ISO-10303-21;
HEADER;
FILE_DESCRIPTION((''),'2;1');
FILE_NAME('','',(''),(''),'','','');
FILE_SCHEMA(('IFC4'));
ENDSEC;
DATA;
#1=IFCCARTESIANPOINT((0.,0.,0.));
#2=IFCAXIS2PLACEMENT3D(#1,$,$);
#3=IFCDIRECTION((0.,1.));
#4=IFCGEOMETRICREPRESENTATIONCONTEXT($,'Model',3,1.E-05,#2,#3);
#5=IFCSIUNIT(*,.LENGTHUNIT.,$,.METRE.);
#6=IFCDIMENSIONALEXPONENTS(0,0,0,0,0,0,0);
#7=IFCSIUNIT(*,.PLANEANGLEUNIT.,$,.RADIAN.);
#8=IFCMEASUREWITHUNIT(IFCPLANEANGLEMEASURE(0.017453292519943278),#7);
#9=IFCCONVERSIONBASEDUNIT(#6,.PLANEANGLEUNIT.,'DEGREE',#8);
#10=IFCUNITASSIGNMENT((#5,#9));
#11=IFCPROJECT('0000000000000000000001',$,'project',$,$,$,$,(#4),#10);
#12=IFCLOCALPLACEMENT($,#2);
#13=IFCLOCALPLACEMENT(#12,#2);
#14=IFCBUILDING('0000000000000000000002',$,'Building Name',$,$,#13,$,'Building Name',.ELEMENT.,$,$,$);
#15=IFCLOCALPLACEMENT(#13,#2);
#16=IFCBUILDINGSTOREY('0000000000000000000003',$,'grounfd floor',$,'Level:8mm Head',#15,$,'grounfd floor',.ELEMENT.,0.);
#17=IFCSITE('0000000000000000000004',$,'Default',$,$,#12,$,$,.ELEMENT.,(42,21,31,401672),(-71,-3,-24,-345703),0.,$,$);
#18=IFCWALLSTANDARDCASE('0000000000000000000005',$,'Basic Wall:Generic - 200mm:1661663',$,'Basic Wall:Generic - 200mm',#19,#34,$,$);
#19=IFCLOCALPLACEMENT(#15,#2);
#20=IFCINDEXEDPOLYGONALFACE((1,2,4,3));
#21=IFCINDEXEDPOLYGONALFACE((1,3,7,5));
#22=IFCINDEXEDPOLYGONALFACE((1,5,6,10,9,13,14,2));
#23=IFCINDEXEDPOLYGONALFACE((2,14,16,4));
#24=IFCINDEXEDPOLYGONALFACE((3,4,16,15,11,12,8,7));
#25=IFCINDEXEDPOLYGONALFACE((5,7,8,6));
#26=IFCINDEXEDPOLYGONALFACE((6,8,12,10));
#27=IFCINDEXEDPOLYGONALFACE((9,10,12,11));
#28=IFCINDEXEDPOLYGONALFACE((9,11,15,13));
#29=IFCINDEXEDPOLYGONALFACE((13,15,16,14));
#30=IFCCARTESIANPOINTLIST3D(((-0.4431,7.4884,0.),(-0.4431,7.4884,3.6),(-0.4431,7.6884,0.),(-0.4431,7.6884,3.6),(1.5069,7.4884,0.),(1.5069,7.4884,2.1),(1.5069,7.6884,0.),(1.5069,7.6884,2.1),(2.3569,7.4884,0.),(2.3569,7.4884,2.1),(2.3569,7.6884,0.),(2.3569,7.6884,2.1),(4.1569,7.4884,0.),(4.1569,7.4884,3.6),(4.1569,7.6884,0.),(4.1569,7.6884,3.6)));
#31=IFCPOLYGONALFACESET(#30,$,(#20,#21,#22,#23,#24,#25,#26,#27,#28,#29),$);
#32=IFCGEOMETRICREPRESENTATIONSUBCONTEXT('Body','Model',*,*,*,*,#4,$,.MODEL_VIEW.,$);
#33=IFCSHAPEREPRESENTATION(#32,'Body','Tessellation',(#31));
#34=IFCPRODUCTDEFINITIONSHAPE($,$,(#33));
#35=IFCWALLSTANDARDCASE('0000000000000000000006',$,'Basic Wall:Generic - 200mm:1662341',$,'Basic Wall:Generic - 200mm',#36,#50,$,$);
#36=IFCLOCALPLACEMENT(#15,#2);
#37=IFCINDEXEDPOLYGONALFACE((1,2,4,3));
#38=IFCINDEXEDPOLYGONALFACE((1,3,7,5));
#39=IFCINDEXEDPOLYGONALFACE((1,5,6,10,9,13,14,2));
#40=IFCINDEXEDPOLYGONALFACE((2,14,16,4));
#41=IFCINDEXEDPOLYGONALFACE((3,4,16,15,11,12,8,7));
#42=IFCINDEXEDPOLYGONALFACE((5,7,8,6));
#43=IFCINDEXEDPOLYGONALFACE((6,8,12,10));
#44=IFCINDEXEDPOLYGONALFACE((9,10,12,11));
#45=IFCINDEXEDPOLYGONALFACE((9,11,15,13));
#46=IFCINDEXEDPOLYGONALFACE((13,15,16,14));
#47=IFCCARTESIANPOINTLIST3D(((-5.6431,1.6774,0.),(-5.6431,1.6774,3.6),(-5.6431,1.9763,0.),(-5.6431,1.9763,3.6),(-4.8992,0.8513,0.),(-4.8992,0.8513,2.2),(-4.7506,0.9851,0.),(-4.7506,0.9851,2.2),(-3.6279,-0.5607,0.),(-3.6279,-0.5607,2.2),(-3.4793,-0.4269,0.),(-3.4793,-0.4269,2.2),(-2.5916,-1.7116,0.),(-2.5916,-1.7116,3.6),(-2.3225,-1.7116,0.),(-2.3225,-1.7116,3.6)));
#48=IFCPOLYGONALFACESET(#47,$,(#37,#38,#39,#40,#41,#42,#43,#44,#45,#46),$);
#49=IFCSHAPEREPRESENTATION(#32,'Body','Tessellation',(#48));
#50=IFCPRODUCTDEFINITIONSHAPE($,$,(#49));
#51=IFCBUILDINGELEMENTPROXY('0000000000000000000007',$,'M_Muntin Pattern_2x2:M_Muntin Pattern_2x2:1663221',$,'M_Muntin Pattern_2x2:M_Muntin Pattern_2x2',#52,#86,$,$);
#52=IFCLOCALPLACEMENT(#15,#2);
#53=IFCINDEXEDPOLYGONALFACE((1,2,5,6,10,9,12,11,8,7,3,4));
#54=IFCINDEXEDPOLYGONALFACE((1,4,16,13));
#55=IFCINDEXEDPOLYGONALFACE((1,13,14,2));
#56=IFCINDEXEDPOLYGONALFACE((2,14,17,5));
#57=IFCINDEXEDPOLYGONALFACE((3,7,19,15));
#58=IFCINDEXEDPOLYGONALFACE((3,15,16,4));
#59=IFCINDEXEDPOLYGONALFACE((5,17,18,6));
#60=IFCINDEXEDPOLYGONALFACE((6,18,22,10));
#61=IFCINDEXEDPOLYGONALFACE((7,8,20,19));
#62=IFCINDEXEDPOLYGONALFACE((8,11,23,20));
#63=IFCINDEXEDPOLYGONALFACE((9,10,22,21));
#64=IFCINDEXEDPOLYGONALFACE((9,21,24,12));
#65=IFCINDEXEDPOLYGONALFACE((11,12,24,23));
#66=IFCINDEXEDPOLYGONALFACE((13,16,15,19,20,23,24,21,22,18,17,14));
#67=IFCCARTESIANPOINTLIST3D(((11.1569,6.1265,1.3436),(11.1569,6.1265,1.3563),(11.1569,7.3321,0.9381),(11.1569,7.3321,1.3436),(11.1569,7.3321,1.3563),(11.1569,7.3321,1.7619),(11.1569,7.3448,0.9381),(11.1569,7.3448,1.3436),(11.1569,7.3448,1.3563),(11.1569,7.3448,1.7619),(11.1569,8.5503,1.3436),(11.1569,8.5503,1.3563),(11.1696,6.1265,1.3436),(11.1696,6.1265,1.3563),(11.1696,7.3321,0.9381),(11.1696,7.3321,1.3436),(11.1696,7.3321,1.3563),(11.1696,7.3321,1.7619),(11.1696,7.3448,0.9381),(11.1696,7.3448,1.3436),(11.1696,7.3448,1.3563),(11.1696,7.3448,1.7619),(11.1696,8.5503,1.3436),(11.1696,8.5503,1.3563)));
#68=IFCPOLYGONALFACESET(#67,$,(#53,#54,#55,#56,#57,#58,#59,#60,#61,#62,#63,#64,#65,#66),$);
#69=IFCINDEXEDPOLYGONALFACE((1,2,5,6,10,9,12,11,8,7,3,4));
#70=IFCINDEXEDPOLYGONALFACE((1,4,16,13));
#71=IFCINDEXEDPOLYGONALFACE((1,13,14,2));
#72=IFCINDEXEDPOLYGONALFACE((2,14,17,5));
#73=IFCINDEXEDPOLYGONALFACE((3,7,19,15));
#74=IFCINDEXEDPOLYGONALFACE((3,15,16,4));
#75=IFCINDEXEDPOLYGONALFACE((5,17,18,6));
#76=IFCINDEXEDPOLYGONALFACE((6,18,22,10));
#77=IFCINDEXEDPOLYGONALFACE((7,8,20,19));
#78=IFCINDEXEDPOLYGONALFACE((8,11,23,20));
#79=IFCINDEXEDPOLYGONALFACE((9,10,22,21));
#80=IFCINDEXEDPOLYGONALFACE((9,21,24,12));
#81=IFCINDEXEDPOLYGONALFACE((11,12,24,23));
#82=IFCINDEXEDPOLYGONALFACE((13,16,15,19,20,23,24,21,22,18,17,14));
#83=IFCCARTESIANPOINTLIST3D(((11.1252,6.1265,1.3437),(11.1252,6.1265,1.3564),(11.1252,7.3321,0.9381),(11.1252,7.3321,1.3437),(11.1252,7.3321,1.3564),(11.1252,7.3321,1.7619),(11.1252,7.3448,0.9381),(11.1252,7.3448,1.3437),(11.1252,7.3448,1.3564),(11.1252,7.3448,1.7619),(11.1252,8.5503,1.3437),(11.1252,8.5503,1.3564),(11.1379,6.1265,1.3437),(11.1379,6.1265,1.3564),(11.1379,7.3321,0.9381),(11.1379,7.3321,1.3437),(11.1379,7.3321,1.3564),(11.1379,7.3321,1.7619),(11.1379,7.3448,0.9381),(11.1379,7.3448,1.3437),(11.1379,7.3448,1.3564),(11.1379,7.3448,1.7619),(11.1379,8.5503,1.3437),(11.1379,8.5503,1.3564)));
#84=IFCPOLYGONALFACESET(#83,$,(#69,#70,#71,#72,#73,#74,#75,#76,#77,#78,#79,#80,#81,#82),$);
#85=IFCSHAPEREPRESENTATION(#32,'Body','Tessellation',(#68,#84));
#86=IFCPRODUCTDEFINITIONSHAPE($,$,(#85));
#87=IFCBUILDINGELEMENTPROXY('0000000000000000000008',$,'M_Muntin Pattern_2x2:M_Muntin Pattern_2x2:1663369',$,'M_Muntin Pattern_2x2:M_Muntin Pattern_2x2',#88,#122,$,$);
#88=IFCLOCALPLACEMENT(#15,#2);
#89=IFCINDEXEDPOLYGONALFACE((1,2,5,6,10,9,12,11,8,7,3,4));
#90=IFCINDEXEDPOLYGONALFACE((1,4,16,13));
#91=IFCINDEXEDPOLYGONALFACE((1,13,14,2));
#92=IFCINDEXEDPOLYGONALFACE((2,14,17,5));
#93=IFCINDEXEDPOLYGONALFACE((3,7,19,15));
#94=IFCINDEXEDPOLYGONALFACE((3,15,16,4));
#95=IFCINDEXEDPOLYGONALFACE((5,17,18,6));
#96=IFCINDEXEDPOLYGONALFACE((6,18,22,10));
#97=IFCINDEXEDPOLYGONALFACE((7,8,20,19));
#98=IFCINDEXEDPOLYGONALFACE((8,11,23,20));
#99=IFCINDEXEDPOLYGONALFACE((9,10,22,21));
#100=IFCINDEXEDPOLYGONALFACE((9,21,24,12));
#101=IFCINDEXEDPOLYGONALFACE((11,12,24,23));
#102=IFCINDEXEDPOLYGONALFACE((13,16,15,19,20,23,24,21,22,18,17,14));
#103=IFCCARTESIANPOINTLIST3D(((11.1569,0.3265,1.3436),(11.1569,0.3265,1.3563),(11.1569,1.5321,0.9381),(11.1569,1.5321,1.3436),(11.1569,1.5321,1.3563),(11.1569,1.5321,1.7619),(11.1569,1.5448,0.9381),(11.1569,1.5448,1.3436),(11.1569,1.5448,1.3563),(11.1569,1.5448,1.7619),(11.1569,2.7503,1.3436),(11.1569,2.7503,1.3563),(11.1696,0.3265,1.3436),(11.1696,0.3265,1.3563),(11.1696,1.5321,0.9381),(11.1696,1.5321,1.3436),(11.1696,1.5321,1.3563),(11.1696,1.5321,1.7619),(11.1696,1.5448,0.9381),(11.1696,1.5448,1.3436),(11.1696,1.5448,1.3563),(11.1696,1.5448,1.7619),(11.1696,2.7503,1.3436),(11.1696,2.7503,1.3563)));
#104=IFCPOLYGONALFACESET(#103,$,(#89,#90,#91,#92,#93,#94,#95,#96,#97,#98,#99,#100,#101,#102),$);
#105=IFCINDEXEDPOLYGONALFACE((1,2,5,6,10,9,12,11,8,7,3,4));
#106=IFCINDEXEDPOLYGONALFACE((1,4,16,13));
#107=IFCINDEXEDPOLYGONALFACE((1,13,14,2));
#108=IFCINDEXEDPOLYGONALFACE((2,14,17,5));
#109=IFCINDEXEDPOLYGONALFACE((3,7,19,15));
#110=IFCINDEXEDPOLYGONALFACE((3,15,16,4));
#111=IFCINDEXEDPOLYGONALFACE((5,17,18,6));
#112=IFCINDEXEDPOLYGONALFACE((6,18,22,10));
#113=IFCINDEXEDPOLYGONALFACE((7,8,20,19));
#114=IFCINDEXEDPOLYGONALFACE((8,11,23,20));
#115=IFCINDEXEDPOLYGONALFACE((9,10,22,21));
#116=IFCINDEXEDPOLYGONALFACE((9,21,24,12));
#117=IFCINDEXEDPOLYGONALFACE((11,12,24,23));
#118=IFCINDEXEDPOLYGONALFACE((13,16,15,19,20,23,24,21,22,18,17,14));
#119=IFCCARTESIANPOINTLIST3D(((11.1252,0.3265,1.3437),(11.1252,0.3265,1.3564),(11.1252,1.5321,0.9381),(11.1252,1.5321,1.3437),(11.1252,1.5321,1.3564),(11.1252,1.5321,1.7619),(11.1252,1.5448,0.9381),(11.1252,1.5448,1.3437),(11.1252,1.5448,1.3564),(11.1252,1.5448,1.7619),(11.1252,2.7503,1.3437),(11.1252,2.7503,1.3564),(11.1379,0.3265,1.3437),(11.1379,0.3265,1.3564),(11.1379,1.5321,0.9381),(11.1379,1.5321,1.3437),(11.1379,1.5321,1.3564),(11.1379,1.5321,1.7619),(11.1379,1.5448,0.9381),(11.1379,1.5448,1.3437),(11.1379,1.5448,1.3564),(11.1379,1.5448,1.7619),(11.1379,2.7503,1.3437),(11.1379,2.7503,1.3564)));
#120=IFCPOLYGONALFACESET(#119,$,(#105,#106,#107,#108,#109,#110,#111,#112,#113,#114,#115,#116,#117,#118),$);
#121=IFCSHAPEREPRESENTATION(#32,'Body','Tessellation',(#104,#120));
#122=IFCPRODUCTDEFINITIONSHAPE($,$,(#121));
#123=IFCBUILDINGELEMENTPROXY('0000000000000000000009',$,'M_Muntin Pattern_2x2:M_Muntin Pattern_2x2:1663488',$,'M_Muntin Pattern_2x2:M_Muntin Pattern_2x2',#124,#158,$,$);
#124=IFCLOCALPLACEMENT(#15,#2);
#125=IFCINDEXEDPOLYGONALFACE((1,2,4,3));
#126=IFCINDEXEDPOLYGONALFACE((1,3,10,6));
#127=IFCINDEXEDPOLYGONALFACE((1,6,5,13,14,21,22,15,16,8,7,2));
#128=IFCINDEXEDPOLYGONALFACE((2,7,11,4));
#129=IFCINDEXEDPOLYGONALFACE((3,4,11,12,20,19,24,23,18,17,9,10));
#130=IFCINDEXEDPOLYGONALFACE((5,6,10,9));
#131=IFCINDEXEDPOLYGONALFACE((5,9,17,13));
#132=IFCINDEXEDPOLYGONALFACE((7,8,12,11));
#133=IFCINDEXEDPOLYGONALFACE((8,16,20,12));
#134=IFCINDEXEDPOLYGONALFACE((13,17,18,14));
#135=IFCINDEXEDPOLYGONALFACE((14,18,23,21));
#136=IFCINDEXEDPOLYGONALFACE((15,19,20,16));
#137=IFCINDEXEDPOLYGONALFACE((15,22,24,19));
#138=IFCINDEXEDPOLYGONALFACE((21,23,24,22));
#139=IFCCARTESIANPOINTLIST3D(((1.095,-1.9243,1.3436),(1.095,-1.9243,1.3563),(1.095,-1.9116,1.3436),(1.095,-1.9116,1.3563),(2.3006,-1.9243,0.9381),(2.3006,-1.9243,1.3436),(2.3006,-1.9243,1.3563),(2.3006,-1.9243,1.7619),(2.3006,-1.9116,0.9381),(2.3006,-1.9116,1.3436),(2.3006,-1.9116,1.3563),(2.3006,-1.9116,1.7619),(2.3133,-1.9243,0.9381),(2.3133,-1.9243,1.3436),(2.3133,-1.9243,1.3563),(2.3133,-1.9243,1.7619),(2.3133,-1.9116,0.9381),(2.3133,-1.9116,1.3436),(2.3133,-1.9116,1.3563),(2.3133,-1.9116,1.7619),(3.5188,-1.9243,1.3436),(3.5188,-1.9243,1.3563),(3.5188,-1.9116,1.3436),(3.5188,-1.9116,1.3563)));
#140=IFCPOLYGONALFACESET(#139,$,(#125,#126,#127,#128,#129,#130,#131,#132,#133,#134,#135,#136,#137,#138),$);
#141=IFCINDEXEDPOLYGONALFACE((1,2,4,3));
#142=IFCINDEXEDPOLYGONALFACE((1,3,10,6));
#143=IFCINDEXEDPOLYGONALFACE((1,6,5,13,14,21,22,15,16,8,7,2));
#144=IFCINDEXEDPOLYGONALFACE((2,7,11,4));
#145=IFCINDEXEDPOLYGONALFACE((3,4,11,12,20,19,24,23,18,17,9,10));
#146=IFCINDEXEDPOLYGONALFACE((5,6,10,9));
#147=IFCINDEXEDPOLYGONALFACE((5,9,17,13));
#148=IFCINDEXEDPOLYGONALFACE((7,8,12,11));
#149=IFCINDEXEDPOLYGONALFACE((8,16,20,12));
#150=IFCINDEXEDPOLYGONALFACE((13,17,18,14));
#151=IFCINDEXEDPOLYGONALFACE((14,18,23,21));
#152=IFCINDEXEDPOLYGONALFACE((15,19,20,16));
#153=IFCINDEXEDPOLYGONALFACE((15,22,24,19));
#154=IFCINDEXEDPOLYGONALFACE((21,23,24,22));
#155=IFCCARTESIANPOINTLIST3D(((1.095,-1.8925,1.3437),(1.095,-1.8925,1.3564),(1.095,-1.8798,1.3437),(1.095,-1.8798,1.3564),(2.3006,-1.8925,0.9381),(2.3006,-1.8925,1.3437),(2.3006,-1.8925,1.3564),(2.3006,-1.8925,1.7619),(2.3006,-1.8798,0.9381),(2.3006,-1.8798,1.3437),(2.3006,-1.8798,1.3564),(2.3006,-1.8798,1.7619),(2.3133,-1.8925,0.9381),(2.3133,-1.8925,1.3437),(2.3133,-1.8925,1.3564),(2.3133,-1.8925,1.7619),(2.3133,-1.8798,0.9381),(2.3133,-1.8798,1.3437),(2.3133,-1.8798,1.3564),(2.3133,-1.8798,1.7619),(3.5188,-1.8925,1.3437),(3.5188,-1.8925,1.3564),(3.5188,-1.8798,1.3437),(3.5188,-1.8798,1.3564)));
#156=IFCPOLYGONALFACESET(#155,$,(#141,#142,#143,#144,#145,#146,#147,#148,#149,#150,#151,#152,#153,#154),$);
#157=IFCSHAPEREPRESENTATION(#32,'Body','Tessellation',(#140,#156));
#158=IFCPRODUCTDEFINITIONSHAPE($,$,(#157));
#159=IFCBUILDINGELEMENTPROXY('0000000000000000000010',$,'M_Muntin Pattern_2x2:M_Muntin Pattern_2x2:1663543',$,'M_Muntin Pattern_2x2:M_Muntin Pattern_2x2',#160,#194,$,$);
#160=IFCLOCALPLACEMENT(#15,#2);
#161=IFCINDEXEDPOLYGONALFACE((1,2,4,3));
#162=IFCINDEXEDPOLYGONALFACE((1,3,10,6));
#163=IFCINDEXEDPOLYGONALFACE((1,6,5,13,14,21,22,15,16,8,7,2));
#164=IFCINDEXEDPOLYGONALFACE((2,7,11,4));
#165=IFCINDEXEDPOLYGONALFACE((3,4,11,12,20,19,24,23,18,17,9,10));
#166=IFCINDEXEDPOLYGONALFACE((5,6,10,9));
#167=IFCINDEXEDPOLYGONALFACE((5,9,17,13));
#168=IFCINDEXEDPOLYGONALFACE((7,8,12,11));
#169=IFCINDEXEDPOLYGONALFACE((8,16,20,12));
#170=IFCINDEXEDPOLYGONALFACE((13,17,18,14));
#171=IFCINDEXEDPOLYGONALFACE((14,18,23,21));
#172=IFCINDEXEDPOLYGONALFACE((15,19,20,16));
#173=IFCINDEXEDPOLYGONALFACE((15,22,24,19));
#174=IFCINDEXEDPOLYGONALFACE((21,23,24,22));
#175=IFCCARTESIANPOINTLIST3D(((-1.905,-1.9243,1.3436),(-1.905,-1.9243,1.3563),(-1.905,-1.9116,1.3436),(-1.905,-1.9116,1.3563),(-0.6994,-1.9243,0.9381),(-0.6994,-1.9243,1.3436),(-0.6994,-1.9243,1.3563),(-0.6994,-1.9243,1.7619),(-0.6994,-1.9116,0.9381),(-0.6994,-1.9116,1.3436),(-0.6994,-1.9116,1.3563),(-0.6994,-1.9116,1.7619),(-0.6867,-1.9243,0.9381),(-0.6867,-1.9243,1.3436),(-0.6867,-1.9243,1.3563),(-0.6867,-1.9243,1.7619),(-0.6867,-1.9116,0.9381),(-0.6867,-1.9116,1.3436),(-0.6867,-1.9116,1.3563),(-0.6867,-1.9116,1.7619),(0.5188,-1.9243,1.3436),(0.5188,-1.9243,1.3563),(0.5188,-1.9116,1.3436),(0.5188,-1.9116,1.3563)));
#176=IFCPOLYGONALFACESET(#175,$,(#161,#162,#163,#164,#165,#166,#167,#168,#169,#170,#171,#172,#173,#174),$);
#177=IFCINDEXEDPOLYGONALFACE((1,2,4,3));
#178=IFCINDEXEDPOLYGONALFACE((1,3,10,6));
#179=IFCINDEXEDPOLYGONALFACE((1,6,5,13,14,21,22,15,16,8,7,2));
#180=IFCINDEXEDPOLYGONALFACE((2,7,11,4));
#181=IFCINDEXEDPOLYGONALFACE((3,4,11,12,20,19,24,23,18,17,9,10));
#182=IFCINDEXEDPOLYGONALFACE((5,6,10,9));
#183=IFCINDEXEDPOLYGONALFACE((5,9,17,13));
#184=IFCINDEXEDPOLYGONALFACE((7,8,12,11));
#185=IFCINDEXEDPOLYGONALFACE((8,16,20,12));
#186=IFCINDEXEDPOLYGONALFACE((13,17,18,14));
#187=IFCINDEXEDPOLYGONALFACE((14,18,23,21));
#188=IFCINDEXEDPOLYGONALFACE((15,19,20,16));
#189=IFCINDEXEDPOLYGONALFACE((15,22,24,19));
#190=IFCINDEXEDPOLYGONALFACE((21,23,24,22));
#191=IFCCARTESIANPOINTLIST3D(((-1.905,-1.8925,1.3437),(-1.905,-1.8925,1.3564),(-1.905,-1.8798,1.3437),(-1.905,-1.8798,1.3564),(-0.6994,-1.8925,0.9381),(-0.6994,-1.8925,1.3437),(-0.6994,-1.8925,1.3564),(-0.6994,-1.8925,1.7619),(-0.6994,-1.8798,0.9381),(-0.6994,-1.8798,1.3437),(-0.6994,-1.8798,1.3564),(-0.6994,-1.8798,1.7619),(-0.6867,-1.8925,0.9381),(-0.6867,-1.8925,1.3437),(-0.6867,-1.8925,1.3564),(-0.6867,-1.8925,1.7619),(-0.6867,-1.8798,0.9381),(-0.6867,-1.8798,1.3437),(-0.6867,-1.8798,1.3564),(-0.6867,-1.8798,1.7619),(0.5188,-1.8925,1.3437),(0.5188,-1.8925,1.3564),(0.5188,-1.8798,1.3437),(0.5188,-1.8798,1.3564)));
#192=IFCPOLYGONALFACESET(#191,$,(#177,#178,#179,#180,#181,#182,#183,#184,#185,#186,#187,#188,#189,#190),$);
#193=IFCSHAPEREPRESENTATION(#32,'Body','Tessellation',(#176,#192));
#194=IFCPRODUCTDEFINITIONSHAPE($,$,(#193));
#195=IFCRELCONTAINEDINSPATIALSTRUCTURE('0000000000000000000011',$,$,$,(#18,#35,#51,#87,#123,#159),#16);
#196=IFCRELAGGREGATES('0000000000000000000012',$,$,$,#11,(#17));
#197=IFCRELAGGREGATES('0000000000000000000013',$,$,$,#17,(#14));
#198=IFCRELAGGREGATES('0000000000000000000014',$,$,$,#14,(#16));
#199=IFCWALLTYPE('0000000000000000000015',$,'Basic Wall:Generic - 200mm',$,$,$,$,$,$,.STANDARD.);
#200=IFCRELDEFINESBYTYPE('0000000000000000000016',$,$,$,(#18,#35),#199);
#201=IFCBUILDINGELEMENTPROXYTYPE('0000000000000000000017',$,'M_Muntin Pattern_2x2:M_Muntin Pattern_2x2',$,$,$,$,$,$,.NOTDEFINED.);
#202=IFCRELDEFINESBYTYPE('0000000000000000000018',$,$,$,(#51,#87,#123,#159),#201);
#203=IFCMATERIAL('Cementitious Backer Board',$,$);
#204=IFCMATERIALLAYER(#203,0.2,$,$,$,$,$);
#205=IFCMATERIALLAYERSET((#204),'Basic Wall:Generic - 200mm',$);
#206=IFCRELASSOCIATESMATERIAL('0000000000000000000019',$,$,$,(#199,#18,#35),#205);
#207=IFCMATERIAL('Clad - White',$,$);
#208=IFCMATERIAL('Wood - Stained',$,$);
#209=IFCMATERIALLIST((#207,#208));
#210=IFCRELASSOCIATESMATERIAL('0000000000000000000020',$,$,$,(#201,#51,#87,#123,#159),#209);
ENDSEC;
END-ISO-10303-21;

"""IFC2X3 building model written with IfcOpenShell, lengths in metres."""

from ifc_helpers import new_model, entity, si_unit, converted_unit, direction, frame, frame_2d, origin, place, context, subcontext, project, spatial, polyline, rectangle, outline, extrude, source, transform, mapped, material, material_list, layer, layer_set, layer_usage, type_object, type_shapes, element, save


model = new_model("IFC2X3")

# Units and contexts
model_context = context("Model", 3, precision=1e-05, world=origin(), true_north=direction((0.0, 1.0)))
body_context = subcontext(model_context, "Body", "Model", "MODEL_VIEW")
ifc_project = project(units=[si_unit("LENGTHUNIT", "METRE"), converted_unit("PLANEANGLEUNIT", "DEGREE", entity("IfcPlaneAngleMeasure", 0.017453292519943278), si_unit("PLANEANGLEUNIT", "RADIAN"), dimensions=[0, 0, 0, 0, 0, 0, 0])], contexts=[model_context])

# Site, building, storey
site_placement = place(None, origin())
site = spatial("IfcSite", under=ifc_project, at=site_placement, Name="Default", CompositionType="ELEMENT", RefLatitude=(42, 21, 31, 401672), RefLongitude=(-71, -3, -24, -345703), RefElevation=0.0)
building_placement = place(site_placement, origin())
building = spatial("IfcBuilding", under=site, at=building_placement, Name="Building Name", LongName="Building Name", CompositionType="ELEMENT")
storey_placement = place(building_placement, origin())
storey = spatial("IfcBuildingStorey", under=building, at=storey_placement, Name="grounfd floor", ObjectType="Level:8mm Head", LongName="grounfd floor", CompositionType="ELEMENT", Elevation=0.0)

# Shared definitions
ifc_material_1 = material(Name="Cementitious Backer Board")
ifc_layer_1 = layer(ifc_material_1, 0.2)
ifc_layer_set_1 = layer_set([ifc_layer_1], Name="Basic Wall:Generic - 200mm")
wall_type = type_object("IfcWallType", Name="Basic Wall:Generic - 200mm", PredefinedType="STANDARD", material=ifc_layer_set_1)

# Walls, openings
ifc_layer_usage_1 = layer_usage(ifc_layer_set_1, "AXIS2", "NEGATIVE", 0.1)
wall_1_placement = place(storey_placement, frame((-0.4431, 7.5884, 0.0)))
wall_1 = element("IfcWallStandardCase", 1, at=wall_1_placement, inside=storey, type_object=wall_type, material=ifc_layer_usage_1, Name="Basic Wall:Generic - 200mm:1661663", ObjectType="Basic Wall:Generic - 200mm", context=body_context, shape_type="SweptSolid", body=[
    extrude(rectangle(XDim=4.6, YDim=0.2, at=frame_2d((2.3, 0.0), x_axis=(-1.0, 0.0))), origin(), (0.0, 0.0, 1.0), 3.6),
])
opening_1_placement = place(wall_1_placement, frame((1.95, -0.1, 0.0)))
element("IfcOpeningElement", 2, at=opening_1_placement, cuts=wall_1, ObjectType="Opening", context=body_context, shape_type="SweptSolid", body=[
    extrude(rectangle(XDim=2.1, YDim=0.85, at=frame_2d((1.05, 0.425), x_axis=(1.0, 0.0))), frame((0.0, 0.0, 0.0), z_axis=(0.0, 1.0, 0.0), x_axis=(0.0, 0.0, 1.0)), (0.0, 0.0, 1.0), 0.2),
])
ifc_layer_usage_2 = layer_usage(ifc_layer_set_1, "AXIS2", "NEGATIVE", 0.1)
wall_2_placement = place(storey_placement, frame((-5.7174, 1.9094, 0.0), z_axis=(0.0, 0.0, 1.0), x_axis=(0.669131, -0.743145, 0.0)))
wall_2 = element("IfcWallStandardCase", 3, at=wall_2_placement, inside=storey, type_object=wall_type, material=ifc_layer_usage_2, Name="Basic Wall:Generic - 200mm:1662341", ObjectType="Basic Wall:Generic - 200mm", context=body_context, shape_type="SweptSolid", body=[
    extrude(outline(polyline([(0.2221, -0.1), (4.7824, -0.1), (4.9625, 0.1), (0.0, 0.1), (0.2221, -0.1)])), origin(), (0.0, 0.0, 1.0), 3.6),
])
opening_2_placement = place(wall_2_placement, frame((1.3337, -0.1, 0.0)))
element("IfcOpeningElement", 4, at=opening_2_placement, cuts=wall_2, ObjectType="Opening", context=body_context, shape_type="SweptSolid", body=[
    extrude(rectangle(XDim=2.2, YDim=1.9, at=frame_2d((1.1, 0.95), x_axis=(1.0, 0.0))), frame((0.0, 0.0, 0.0), z_axis=(0.0, 1.0, 0.0), x_axis=(0.0, 0.0, 1.0)), (0.0, 0.0, 1.0), 0.2),
])

# Building element proxies
ifc_material_2 = material(Name="Clad - White")
ifc_material_3 = material(Name="Wood - Stained")
ifc_material_list = material_list([ifc_material_2, ifc_material_3])
building_element_proxy_type_1 = type_object("IfcBuildingElementProxyType", Name="M_Muntin Pattern_2x2:M_Muntin Pattern_2x2", PredefinedType="NOTDEFINED", material=ifc_material_list)
shared_shape_1 = source(origin(), body_context, "Body", "SweptSolid", [
    extrude(outline(polyline([(0.0064, -0.0064), (0.4119, -0.0064), (0.4119, 0.0063), (0.0064, 0.0063), (0.0064, 1.2119), (-0.0063, 1.2119), (-0.0063, 0.0063), (-0.4119, 0.0063), (-0.4119, -0.0064), (-0.0063, -0.0064), (-0.0063, -1.2119), (0.0064, -1.2119), (0.0064, -0.0064)])), frame((0.0, -0.0222, 0.4119), z_axis=(0.0, 1.0, 0.0), x_axis=(0.0, 0.0, 1.0)), (0.0, 0.0, 1.0), 0.0127),
    extrude(outline(polyline([(0.0064, -0.0064), (0.4119, -0.0064), (0.4119, 0.0063), (0.0064, 0.0063), (0.0064, 1.2119), (-0.0063, 1.2119), (-0.0063, 0.0063), (-0.4119, 0.0063), (-0.4119, -0.0064), (-0.0063, -0.0064), (-0.0063, -1.2119), (0.0064, -1.2119), (0.0064, -0.0064)])), frame((0.0, 0.0095, 0.4119), z_axis=(0.0, 1.0, 0.0), x_axis=(0.0, 0.0, 1.0)), (0.0, 0.0, 1.0), 0.0127),
])
type_shapes(building_element_proxy_type_1, [shared_shape_1])
for number, where, z_axis, x_axis, name in (
    (5, (11.1474, 7.3384, 0.9381), (0.0, 0.0, 1.0), (0.0, 1.0, 0.0), "M_Muntin Pattern_2x2:M_Muntin Pattern_2x2:1663221"),
    (6, (11.1474, 1.5384, 0.9381), (0.0, 0.0, 1.0), (0.0, 1.0, 0.0), "M_Muntin Pattern_2x2:M_Muntin Pattern_2x2:1663369"),
):
    element("IfcBuildingElementProxy", number, at=place(storey_placement, frame(where, z_axis=z_axis, x_axis=x_axis)), inside=storey, type_object=building_element_proxy_type_1, material=ifc_material_list, Name=name, ObjectType="M_Muntin Pattern_2x2:M_Muntin Pattern_2x2", context=body_context, shape_type="MappedRepresentation", body=[
        mapped(shared_shape_1, transform((0.0, 0.0, 0.0), scale=1.0)),
    ])
for number, where, name in (
    (7, (2.3069, -1.902, 0.9381), "M_Muntin Pattern_2x2:M_Muntin Pattern_2x2:1663488"),
    (8, (-0.6931, -1.902, 0.9381), "M_Muntin Pattern_2x2:M_Muntin Pattern_2x2:1663543"),
):
    element("IfcBuildingElementProxy", number, at=place(storey_placement, frame(where)), inside=storey, type_object=building_element_proxy_type_1, material=ifc_material_list, Name=name, ObjectType="M_Muntin Pattern_2x2:M_Muntin Pattern_2x2", context=body_context, shape_type="MappedRepresentation", body=[
        mapped(shared_shape_1, transform((0.0, 0.0, 0.0), scale=1.0)),
    ])

save(model, "model.ifc")
